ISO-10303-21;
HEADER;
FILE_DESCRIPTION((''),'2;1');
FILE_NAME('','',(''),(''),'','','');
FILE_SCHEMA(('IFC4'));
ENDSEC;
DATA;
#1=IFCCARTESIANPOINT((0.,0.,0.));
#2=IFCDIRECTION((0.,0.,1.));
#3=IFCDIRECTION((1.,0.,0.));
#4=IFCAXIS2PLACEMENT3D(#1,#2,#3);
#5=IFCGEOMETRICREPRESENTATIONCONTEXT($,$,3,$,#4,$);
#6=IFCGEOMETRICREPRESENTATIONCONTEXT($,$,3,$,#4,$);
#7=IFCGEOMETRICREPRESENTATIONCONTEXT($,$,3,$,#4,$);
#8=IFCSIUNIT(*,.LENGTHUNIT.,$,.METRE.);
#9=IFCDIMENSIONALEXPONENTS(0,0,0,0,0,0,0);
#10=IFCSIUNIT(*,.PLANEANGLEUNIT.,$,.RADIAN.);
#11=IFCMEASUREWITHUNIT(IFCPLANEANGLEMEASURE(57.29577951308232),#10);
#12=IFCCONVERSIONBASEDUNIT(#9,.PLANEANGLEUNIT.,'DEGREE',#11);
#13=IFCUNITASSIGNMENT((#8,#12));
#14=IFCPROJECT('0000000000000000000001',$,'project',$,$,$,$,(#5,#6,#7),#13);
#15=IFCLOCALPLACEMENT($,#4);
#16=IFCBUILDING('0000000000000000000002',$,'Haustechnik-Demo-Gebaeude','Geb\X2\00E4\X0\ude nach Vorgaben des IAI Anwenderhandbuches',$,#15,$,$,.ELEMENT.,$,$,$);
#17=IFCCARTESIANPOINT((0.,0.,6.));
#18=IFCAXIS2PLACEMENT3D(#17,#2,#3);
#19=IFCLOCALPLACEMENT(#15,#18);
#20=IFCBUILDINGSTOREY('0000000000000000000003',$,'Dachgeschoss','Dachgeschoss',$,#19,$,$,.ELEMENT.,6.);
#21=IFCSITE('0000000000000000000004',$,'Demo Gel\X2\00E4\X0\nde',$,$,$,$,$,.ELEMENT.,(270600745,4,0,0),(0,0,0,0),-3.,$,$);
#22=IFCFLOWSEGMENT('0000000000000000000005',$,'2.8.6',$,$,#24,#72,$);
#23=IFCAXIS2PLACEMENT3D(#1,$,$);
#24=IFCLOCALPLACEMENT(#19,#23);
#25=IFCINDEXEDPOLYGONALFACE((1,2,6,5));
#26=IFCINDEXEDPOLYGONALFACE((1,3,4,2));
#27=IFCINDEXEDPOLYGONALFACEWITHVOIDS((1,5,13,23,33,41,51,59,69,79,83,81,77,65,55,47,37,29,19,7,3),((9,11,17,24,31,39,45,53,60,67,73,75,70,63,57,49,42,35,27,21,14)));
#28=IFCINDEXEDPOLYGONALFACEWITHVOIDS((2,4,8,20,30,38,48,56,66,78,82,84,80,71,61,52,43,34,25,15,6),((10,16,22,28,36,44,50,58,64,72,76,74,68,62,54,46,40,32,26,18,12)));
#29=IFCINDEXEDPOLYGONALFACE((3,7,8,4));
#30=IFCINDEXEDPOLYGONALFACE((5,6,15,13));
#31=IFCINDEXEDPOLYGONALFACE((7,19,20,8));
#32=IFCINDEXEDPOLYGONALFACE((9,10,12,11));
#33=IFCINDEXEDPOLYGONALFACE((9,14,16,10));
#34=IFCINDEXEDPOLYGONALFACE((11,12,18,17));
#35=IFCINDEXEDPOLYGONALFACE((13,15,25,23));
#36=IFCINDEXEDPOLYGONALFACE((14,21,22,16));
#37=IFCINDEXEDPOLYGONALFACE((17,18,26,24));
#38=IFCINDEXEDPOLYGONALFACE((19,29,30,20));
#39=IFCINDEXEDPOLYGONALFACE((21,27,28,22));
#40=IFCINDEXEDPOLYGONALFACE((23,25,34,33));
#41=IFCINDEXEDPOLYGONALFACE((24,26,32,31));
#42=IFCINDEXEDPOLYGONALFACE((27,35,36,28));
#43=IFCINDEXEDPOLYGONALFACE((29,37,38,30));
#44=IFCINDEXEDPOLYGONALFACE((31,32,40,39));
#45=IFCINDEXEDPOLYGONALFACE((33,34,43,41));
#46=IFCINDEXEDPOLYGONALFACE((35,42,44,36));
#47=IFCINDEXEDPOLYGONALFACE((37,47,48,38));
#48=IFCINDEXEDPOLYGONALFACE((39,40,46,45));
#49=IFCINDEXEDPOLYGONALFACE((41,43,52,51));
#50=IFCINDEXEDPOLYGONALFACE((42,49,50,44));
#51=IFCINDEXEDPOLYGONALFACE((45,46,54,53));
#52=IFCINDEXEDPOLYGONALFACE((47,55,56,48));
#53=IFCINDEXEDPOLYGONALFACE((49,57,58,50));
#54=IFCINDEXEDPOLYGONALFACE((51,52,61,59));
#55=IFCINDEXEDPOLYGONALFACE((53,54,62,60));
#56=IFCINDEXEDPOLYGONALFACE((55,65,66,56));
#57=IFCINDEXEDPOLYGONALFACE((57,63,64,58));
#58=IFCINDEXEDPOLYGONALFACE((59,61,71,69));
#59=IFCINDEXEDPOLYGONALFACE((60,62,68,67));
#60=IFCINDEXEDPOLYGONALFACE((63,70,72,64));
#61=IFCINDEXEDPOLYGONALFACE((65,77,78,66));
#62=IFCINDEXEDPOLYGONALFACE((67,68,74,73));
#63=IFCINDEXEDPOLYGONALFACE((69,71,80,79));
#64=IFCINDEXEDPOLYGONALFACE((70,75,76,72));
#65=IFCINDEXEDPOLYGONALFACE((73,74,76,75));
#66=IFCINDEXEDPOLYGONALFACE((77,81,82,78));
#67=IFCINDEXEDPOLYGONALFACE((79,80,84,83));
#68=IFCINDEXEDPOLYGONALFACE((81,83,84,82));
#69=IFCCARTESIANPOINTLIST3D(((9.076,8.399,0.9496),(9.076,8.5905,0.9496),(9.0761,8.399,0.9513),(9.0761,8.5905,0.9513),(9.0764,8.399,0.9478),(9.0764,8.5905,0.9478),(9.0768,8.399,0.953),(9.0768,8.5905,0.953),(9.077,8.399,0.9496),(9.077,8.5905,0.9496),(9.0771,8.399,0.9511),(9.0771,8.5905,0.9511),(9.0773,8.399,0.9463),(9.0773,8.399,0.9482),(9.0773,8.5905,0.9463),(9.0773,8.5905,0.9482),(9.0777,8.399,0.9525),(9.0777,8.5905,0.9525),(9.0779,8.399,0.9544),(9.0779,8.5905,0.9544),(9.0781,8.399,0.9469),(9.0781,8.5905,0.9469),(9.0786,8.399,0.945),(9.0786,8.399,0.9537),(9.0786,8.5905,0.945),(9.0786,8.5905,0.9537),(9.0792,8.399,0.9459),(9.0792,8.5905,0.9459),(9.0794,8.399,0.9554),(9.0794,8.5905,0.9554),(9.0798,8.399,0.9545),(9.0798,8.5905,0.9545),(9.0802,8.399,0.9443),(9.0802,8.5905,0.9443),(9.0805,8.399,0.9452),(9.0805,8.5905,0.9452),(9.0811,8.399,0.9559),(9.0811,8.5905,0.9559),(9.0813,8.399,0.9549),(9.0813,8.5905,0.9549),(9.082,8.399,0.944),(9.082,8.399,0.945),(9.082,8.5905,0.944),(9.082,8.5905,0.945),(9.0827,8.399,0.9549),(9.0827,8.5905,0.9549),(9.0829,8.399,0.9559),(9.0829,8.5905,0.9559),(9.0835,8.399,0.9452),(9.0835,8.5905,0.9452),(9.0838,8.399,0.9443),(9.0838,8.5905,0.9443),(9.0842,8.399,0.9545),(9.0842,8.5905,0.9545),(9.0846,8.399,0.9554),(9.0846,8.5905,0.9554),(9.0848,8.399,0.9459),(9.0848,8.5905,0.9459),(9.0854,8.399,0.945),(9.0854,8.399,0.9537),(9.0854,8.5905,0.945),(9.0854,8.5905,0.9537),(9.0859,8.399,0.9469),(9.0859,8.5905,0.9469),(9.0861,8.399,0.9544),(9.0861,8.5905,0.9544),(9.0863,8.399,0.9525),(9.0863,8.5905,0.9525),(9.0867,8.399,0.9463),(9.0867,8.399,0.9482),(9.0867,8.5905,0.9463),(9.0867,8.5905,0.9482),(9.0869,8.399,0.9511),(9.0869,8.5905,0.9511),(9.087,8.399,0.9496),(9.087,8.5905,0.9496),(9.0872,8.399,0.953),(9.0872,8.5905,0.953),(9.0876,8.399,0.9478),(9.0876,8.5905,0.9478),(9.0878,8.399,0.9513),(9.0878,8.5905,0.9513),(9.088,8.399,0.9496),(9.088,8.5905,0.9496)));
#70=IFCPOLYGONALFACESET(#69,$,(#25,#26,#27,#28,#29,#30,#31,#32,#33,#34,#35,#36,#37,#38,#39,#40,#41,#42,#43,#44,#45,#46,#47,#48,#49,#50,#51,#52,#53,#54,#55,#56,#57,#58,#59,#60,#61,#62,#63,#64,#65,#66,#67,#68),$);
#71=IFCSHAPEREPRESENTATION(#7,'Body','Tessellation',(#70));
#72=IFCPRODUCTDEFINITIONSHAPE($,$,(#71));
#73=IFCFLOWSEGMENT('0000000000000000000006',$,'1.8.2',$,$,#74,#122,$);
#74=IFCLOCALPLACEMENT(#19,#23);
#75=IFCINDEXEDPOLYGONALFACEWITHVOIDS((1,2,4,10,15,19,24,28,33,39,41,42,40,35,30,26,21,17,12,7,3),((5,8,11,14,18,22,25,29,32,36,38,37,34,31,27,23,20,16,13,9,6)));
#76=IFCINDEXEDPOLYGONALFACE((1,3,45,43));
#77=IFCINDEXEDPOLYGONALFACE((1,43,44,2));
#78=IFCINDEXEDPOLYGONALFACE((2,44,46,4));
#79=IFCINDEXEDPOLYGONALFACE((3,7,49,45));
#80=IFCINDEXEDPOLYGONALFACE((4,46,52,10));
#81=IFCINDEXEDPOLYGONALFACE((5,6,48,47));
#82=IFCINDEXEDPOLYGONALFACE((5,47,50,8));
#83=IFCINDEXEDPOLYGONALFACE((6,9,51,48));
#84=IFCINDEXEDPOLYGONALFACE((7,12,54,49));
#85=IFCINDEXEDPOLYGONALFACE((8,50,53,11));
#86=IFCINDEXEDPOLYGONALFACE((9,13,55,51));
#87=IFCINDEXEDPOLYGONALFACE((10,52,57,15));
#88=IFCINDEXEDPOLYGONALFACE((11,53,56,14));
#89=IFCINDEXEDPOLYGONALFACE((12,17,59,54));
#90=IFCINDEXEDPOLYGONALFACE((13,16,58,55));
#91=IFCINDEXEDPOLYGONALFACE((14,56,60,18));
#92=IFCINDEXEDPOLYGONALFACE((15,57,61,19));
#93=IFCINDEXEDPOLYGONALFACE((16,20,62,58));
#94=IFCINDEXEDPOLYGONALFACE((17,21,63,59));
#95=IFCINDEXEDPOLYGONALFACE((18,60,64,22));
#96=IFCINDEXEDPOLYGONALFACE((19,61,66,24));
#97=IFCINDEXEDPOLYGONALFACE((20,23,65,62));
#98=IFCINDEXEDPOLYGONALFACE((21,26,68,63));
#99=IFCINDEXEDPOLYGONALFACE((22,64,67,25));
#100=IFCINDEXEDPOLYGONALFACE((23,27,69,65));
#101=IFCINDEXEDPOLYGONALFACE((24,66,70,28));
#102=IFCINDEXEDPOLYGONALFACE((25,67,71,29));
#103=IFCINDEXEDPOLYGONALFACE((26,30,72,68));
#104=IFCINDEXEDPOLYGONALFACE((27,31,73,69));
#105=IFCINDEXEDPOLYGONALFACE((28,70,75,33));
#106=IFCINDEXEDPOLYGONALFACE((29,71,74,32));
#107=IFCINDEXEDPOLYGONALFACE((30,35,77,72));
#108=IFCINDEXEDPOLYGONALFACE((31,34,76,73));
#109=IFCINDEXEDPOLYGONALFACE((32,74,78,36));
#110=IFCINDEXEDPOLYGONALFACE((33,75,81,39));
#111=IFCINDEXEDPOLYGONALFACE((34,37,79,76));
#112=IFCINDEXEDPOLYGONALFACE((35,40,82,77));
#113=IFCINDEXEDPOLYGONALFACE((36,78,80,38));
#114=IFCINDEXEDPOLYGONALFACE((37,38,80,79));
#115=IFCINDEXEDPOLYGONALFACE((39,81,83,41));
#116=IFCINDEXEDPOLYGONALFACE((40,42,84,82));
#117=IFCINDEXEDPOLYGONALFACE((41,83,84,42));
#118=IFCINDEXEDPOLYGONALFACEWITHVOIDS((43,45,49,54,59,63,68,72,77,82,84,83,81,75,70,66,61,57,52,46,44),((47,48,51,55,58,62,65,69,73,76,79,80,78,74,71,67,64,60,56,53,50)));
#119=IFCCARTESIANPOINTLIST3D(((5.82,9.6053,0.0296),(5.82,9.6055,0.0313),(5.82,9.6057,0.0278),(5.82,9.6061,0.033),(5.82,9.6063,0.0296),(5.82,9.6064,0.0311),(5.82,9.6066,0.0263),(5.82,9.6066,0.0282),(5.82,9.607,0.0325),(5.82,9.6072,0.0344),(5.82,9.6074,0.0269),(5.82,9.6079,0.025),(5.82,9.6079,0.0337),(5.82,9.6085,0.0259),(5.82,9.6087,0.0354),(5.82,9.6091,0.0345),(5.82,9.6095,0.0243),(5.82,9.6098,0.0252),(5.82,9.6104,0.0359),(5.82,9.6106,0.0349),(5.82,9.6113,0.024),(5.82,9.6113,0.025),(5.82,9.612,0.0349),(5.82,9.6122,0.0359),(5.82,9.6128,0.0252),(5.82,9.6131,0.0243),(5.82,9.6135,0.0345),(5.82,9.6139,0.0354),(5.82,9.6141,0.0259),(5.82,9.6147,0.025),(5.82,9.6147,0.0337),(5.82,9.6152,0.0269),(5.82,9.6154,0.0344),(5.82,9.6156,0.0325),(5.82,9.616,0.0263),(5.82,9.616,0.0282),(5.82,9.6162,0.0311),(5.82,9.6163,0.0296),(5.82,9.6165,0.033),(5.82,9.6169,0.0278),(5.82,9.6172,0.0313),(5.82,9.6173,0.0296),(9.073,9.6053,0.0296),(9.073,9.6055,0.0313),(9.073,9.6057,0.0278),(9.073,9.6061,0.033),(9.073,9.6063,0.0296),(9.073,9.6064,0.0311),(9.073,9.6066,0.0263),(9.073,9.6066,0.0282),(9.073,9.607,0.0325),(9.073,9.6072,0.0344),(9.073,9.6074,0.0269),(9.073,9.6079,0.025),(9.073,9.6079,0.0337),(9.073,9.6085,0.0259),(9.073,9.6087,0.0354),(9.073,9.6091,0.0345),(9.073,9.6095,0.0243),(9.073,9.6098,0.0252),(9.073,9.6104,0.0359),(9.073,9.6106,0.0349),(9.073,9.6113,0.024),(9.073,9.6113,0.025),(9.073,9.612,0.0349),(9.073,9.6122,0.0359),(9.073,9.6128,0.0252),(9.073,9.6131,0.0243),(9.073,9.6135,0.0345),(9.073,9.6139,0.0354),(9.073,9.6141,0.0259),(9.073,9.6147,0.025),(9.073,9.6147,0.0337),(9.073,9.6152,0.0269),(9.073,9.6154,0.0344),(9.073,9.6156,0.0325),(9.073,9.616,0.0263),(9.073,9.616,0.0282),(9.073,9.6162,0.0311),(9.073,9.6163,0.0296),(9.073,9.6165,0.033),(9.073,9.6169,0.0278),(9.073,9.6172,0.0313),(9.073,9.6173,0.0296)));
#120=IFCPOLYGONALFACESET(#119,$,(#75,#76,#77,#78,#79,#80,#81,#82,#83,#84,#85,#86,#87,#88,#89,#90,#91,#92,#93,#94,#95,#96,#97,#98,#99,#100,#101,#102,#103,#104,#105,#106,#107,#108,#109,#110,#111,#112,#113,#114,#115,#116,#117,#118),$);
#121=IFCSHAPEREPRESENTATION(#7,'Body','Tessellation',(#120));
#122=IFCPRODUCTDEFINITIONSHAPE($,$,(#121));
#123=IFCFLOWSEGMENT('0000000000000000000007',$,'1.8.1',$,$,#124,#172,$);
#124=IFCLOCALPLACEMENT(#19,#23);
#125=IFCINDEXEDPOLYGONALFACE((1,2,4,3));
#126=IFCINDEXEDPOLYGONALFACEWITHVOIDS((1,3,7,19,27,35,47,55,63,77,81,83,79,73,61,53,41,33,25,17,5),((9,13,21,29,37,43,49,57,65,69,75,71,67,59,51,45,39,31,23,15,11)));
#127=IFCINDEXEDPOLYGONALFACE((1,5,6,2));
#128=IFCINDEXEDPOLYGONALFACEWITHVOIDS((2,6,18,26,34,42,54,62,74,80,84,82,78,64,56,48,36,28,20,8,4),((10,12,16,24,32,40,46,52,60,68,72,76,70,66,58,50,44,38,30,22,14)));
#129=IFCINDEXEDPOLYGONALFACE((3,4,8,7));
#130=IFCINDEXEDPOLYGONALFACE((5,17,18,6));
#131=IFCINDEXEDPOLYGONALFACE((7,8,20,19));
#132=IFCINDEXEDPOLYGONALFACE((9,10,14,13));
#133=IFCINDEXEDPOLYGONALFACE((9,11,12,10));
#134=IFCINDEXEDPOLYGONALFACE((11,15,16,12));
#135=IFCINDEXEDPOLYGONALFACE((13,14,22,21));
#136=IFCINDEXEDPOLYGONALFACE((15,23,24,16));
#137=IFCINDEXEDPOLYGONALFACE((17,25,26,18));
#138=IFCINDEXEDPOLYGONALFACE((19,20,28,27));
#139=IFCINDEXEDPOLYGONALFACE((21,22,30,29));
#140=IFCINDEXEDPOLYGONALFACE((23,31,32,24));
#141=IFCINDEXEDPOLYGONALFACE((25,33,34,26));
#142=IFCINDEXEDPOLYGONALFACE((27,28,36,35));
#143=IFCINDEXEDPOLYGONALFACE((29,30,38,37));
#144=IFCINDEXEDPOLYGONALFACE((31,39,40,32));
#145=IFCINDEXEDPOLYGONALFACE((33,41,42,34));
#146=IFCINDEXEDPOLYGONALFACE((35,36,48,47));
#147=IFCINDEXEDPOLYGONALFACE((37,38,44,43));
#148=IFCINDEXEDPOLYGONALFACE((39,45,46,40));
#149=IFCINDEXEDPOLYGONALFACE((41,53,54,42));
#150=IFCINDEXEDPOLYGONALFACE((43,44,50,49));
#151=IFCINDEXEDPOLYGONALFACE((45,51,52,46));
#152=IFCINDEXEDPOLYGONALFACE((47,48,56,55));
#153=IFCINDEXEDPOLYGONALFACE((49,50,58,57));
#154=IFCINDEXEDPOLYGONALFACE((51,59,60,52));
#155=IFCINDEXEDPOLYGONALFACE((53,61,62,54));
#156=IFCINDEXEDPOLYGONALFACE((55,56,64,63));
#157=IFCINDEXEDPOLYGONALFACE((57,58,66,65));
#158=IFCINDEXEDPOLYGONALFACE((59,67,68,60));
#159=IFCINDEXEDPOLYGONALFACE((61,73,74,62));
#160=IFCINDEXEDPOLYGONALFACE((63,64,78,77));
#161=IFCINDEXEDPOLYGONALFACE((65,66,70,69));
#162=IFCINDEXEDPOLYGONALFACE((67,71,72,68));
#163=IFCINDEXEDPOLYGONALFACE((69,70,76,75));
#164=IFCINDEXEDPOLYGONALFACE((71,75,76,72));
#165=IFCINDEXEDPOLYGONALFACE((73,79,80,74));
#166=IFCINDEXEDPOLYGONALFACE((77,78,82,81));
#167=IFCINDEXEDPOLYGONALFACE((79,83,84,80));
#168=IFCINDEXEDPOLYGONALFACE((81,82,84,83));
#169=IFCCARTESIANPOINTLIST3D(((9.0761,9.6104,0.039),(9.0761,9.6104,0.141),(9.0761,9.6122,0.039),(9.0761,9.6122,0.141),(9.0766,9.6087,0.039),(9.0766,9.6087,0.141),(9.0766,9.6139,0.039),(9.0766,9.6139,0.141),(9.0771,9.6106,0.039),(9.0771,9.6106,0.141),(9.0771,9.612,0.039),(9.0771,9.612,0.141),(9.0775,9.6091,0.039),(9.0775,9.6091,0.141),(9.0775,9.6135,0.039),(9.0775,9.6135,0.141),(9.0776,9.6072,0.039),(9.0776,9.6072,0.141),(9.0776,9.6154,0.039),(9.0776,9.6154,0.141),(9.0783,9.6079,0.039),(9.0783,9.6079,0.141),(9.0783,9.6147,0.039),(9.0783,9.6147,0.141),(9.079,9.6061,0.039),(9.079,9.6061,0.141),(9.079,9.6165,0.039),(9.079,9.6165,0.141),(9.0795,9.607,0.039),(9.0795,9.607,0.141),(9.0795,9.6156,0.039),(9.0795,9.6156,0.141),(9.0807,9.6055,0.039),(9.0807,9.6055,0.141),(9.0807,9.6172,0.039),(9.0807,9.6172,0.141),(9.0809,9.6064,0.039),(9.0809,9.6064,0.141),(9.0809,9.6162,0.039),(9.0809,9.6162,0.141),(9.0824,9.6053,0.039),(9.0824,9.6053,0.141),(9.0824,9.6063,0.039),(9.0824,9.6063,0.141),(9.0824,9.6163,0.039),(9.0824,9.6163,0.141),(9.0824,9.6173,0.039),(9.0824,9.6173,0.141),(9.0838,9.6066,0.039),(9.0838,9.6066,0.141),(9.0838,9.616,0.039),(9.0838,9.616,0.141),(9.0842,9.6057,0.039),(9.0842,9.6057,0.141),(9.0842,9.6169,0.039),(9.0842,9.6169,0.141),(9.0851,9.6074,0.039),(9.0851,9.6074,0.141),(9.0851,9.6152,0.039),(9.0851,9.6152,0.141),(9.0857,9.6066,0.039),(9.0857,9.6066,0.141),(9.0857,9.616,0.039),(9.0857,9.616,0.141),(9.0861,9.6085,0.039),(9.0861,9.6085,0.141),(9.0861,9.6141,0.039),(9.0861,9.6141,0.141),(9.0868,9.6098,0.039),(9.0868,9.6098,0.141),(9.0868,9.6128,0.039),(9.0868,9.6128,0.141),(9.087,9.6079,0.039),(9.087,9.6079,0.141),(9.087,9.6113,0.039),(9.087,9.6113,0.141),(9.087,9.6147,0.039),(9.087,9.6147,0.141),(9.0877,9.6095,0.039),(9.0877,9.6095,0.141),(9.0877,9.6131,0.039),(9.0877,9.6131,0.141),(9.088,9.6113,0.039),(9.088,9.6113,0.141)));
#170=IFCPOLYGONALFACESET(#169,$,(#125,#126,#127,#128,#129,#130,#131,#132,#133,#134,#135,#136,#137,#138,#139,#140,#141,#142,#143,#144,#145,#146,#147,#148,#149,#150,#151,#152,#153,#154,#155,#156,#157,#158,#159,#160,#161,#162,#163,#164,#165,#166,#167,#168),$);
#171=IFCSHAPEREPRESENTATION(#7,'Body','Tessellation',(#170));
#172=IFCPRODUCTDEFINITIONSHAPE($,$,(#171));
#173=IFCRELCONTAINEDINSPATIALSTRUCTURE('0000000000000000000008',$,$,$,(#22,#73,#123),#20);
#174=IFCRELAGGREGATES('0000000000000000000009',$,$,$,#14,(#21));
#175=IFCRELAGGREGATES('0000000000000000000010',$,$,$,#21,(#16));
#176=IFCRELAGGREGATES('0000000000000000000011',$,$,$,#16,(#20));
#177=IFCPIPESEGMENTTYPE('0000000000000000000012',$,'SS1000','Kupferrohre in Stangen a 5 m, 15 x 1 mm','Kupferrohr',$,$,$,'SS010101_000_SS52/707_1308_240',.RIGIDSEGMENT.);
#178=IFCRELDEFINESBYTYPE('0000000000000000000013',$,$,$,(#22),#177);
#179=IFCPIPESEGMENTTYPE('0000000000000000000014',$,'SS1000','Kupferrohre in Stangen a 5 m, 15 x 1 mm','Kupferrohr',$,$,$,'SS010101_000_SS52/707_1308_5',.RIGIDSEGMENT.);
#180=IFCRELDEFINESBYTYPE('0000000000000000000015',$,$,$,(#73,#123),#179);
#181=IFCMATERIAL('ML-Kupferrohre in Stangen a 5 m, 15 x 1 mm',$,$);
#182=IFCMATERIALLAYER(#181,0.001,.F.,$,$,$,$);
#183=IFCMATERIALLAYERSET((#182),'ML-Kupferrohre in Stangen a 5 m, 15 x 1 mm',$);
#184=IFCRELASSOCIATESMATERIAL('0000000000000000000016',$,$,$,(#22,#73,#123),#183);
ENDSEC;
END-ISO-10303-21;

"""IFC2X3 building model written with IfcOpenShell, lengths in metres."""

from ifc_helpers import new_model, entity, si_unit, converted_unit, frame, origin_with_axes, origin_2d_with_axis, place, context, project, spatial, hollow_circle, extrude, material, layer, layer_set, layer_usage, type_object, element, save


model = new_model("IFC2X3")

# Units and contexts
context_of_model_1 = context(None, 3, world=origin_with_axes())
context_of_model_2 = context(None, 3, world=origin_with_axes())
context_of_model_3 = context(None, 3, world=origin_with_axes())
ifc_project = project(units=[si_unit("LENGTHUNIT", "METRE"), converted_unit("PLANEANGLEUNIT", "DEGREE", entity("IfcPlaneAngleMeasure", 57.29577951308232), si_unit("PLANEANGLEUNIT", "RADIAN"), dimensions=[0, 0, 0, 0, 0, 0, 0])], contexts=[context_of_model_1, context_of_model_2, context_of_model_3])

# Site, building, storey
site = spatial("IfcSite", under=ifc_project, Name="Demo Gelände", CompositionType="ELEMENT", RefLatitude=(270600745, 4, 0, 0), RefLongitude=(0, 0, 0, 0), RefElevation=-3.0)
building_placement = place(None, origin_with_axes())
building = spatial("IfcBuilding", under=site, at=building_placement, Name="Haustechnik-Demo-Gebaeude", Description="Gebäude nach Vorgaben des IAI Anwenderhandbuches", CompositionType="ELEMENT")
storey_placement = place(building_placement, frame((0.0, 0.0, 6.0), z_axis=(0.0, 0.0, 1.0), x_axis=(1.0, 0.0, 0.0)))
storey = spatial("IfcBuildingStorey", under=building, at=storey_placement, Name="Dachgeschoss", Description="Dachgeschoss", CompositionType="ELEMENT", Elevation=6.0)

# Flow segments
ifc_material = material(Name="ML-Kupferrohre in Stangen a 5 m, 15 x 1 mm")
ifc_layer = layer(ifc_material, 0.001, ventilated=False)
ifc_layer_set = layer_set([ifc_layer], Name="ML-Kupferrohre in Stangen a 5 m, 15 x 1 mm")
ifc_layer_usage = layer_usage(ifc_layer_set, "AXIS2", "POSITIVE", 0.0)
pipe_segment_type_1 = type_object("IfcPipeSegmentType", Name="SS1000", Description="Kupferrohre in Stangen a 5 m, 15 x 1 mm", ApplicableOccurrence="Kupferrohr", ElementType="SS010101_000_SS52/707_1308_240", PredefinedType="RIGIDSEGMENT")
flow_segment_1_placement = place(storey_placement, frame((9.082, 8.399, 0.95), z_axis=(0.0, 1.0, 0.0), x_axis=(0.0, 0.0, -1.0)))
element("IfcFlowSegment", 1, at=flow_segment_1_placement, inside=storey, type_object=pipe_segment_type_1, material=ifc_layer_usage, Name="2.8.6", context=context_of_model_3, shape_type="SweptSolid", body=[
    extrude(hollow_circle(Radius=0.006, WallThickness=0.001, at=origin_2d_with_axis()), origin_with_axes(), (0.0, 0.0, 1.0), 0.1915),
])
pipe_segment_type_2 = type_object("IfcPipeSegmentType", Name="SS1000", Description="Kupferrohre in Stangen a 5 m, 15 x 1 mm", ApplicableOccurrence="Kupferrohr", ElementType="SS010101_000_SS52/707_1308_5", PredefinedType="RIGIDSEGMENT")
flow_segment_2_placement = place(storey_placement, frame((5.82, 9.6113, 0.03), z_axis=(1.0, 0.0, 0.0), x_axis=(0.0, 0.0, -1.0)))
element("IfcFlowSegment", 2, at=flow_segment_2_placement, inside=storey, type_object=pipe_segment_type_2, material=ifc_layer_usage, Name="1.8.2", context=context_of_model_3, shape_type="SweptSolid", body=[
    extrude(hollow_circle(Radius=0.006, WallThickness=0.001, at=origin_2d_with_axis()), origin_with_axes(), (0.0, 0.0, 1.0), 3.253),
])
flow_segment_3_placement = place(storey_placement, frame((9.082, 9.6113, 0.039), z_axis=(0.0, 0.0, 1.0), x_axis=(1.0, 0.0, 0.0)))
element("IfcFlowSegment", 3, at=flow_segment_3_placement, inside=storey, type_object=pipe_segment_type_2, material=ifc_layer_usage, Name="1.8.1", context=context_of_model_3, shape_type="SweptSolid", body=[
    extrude(hollow_circle(Radius=0.006, WallThickness=0.001, at=origin_2d_with_axis()), origin_with_axes(), (0.0, 0.0, 1.0), 0.102),
])

save(model, "model.ifc")
